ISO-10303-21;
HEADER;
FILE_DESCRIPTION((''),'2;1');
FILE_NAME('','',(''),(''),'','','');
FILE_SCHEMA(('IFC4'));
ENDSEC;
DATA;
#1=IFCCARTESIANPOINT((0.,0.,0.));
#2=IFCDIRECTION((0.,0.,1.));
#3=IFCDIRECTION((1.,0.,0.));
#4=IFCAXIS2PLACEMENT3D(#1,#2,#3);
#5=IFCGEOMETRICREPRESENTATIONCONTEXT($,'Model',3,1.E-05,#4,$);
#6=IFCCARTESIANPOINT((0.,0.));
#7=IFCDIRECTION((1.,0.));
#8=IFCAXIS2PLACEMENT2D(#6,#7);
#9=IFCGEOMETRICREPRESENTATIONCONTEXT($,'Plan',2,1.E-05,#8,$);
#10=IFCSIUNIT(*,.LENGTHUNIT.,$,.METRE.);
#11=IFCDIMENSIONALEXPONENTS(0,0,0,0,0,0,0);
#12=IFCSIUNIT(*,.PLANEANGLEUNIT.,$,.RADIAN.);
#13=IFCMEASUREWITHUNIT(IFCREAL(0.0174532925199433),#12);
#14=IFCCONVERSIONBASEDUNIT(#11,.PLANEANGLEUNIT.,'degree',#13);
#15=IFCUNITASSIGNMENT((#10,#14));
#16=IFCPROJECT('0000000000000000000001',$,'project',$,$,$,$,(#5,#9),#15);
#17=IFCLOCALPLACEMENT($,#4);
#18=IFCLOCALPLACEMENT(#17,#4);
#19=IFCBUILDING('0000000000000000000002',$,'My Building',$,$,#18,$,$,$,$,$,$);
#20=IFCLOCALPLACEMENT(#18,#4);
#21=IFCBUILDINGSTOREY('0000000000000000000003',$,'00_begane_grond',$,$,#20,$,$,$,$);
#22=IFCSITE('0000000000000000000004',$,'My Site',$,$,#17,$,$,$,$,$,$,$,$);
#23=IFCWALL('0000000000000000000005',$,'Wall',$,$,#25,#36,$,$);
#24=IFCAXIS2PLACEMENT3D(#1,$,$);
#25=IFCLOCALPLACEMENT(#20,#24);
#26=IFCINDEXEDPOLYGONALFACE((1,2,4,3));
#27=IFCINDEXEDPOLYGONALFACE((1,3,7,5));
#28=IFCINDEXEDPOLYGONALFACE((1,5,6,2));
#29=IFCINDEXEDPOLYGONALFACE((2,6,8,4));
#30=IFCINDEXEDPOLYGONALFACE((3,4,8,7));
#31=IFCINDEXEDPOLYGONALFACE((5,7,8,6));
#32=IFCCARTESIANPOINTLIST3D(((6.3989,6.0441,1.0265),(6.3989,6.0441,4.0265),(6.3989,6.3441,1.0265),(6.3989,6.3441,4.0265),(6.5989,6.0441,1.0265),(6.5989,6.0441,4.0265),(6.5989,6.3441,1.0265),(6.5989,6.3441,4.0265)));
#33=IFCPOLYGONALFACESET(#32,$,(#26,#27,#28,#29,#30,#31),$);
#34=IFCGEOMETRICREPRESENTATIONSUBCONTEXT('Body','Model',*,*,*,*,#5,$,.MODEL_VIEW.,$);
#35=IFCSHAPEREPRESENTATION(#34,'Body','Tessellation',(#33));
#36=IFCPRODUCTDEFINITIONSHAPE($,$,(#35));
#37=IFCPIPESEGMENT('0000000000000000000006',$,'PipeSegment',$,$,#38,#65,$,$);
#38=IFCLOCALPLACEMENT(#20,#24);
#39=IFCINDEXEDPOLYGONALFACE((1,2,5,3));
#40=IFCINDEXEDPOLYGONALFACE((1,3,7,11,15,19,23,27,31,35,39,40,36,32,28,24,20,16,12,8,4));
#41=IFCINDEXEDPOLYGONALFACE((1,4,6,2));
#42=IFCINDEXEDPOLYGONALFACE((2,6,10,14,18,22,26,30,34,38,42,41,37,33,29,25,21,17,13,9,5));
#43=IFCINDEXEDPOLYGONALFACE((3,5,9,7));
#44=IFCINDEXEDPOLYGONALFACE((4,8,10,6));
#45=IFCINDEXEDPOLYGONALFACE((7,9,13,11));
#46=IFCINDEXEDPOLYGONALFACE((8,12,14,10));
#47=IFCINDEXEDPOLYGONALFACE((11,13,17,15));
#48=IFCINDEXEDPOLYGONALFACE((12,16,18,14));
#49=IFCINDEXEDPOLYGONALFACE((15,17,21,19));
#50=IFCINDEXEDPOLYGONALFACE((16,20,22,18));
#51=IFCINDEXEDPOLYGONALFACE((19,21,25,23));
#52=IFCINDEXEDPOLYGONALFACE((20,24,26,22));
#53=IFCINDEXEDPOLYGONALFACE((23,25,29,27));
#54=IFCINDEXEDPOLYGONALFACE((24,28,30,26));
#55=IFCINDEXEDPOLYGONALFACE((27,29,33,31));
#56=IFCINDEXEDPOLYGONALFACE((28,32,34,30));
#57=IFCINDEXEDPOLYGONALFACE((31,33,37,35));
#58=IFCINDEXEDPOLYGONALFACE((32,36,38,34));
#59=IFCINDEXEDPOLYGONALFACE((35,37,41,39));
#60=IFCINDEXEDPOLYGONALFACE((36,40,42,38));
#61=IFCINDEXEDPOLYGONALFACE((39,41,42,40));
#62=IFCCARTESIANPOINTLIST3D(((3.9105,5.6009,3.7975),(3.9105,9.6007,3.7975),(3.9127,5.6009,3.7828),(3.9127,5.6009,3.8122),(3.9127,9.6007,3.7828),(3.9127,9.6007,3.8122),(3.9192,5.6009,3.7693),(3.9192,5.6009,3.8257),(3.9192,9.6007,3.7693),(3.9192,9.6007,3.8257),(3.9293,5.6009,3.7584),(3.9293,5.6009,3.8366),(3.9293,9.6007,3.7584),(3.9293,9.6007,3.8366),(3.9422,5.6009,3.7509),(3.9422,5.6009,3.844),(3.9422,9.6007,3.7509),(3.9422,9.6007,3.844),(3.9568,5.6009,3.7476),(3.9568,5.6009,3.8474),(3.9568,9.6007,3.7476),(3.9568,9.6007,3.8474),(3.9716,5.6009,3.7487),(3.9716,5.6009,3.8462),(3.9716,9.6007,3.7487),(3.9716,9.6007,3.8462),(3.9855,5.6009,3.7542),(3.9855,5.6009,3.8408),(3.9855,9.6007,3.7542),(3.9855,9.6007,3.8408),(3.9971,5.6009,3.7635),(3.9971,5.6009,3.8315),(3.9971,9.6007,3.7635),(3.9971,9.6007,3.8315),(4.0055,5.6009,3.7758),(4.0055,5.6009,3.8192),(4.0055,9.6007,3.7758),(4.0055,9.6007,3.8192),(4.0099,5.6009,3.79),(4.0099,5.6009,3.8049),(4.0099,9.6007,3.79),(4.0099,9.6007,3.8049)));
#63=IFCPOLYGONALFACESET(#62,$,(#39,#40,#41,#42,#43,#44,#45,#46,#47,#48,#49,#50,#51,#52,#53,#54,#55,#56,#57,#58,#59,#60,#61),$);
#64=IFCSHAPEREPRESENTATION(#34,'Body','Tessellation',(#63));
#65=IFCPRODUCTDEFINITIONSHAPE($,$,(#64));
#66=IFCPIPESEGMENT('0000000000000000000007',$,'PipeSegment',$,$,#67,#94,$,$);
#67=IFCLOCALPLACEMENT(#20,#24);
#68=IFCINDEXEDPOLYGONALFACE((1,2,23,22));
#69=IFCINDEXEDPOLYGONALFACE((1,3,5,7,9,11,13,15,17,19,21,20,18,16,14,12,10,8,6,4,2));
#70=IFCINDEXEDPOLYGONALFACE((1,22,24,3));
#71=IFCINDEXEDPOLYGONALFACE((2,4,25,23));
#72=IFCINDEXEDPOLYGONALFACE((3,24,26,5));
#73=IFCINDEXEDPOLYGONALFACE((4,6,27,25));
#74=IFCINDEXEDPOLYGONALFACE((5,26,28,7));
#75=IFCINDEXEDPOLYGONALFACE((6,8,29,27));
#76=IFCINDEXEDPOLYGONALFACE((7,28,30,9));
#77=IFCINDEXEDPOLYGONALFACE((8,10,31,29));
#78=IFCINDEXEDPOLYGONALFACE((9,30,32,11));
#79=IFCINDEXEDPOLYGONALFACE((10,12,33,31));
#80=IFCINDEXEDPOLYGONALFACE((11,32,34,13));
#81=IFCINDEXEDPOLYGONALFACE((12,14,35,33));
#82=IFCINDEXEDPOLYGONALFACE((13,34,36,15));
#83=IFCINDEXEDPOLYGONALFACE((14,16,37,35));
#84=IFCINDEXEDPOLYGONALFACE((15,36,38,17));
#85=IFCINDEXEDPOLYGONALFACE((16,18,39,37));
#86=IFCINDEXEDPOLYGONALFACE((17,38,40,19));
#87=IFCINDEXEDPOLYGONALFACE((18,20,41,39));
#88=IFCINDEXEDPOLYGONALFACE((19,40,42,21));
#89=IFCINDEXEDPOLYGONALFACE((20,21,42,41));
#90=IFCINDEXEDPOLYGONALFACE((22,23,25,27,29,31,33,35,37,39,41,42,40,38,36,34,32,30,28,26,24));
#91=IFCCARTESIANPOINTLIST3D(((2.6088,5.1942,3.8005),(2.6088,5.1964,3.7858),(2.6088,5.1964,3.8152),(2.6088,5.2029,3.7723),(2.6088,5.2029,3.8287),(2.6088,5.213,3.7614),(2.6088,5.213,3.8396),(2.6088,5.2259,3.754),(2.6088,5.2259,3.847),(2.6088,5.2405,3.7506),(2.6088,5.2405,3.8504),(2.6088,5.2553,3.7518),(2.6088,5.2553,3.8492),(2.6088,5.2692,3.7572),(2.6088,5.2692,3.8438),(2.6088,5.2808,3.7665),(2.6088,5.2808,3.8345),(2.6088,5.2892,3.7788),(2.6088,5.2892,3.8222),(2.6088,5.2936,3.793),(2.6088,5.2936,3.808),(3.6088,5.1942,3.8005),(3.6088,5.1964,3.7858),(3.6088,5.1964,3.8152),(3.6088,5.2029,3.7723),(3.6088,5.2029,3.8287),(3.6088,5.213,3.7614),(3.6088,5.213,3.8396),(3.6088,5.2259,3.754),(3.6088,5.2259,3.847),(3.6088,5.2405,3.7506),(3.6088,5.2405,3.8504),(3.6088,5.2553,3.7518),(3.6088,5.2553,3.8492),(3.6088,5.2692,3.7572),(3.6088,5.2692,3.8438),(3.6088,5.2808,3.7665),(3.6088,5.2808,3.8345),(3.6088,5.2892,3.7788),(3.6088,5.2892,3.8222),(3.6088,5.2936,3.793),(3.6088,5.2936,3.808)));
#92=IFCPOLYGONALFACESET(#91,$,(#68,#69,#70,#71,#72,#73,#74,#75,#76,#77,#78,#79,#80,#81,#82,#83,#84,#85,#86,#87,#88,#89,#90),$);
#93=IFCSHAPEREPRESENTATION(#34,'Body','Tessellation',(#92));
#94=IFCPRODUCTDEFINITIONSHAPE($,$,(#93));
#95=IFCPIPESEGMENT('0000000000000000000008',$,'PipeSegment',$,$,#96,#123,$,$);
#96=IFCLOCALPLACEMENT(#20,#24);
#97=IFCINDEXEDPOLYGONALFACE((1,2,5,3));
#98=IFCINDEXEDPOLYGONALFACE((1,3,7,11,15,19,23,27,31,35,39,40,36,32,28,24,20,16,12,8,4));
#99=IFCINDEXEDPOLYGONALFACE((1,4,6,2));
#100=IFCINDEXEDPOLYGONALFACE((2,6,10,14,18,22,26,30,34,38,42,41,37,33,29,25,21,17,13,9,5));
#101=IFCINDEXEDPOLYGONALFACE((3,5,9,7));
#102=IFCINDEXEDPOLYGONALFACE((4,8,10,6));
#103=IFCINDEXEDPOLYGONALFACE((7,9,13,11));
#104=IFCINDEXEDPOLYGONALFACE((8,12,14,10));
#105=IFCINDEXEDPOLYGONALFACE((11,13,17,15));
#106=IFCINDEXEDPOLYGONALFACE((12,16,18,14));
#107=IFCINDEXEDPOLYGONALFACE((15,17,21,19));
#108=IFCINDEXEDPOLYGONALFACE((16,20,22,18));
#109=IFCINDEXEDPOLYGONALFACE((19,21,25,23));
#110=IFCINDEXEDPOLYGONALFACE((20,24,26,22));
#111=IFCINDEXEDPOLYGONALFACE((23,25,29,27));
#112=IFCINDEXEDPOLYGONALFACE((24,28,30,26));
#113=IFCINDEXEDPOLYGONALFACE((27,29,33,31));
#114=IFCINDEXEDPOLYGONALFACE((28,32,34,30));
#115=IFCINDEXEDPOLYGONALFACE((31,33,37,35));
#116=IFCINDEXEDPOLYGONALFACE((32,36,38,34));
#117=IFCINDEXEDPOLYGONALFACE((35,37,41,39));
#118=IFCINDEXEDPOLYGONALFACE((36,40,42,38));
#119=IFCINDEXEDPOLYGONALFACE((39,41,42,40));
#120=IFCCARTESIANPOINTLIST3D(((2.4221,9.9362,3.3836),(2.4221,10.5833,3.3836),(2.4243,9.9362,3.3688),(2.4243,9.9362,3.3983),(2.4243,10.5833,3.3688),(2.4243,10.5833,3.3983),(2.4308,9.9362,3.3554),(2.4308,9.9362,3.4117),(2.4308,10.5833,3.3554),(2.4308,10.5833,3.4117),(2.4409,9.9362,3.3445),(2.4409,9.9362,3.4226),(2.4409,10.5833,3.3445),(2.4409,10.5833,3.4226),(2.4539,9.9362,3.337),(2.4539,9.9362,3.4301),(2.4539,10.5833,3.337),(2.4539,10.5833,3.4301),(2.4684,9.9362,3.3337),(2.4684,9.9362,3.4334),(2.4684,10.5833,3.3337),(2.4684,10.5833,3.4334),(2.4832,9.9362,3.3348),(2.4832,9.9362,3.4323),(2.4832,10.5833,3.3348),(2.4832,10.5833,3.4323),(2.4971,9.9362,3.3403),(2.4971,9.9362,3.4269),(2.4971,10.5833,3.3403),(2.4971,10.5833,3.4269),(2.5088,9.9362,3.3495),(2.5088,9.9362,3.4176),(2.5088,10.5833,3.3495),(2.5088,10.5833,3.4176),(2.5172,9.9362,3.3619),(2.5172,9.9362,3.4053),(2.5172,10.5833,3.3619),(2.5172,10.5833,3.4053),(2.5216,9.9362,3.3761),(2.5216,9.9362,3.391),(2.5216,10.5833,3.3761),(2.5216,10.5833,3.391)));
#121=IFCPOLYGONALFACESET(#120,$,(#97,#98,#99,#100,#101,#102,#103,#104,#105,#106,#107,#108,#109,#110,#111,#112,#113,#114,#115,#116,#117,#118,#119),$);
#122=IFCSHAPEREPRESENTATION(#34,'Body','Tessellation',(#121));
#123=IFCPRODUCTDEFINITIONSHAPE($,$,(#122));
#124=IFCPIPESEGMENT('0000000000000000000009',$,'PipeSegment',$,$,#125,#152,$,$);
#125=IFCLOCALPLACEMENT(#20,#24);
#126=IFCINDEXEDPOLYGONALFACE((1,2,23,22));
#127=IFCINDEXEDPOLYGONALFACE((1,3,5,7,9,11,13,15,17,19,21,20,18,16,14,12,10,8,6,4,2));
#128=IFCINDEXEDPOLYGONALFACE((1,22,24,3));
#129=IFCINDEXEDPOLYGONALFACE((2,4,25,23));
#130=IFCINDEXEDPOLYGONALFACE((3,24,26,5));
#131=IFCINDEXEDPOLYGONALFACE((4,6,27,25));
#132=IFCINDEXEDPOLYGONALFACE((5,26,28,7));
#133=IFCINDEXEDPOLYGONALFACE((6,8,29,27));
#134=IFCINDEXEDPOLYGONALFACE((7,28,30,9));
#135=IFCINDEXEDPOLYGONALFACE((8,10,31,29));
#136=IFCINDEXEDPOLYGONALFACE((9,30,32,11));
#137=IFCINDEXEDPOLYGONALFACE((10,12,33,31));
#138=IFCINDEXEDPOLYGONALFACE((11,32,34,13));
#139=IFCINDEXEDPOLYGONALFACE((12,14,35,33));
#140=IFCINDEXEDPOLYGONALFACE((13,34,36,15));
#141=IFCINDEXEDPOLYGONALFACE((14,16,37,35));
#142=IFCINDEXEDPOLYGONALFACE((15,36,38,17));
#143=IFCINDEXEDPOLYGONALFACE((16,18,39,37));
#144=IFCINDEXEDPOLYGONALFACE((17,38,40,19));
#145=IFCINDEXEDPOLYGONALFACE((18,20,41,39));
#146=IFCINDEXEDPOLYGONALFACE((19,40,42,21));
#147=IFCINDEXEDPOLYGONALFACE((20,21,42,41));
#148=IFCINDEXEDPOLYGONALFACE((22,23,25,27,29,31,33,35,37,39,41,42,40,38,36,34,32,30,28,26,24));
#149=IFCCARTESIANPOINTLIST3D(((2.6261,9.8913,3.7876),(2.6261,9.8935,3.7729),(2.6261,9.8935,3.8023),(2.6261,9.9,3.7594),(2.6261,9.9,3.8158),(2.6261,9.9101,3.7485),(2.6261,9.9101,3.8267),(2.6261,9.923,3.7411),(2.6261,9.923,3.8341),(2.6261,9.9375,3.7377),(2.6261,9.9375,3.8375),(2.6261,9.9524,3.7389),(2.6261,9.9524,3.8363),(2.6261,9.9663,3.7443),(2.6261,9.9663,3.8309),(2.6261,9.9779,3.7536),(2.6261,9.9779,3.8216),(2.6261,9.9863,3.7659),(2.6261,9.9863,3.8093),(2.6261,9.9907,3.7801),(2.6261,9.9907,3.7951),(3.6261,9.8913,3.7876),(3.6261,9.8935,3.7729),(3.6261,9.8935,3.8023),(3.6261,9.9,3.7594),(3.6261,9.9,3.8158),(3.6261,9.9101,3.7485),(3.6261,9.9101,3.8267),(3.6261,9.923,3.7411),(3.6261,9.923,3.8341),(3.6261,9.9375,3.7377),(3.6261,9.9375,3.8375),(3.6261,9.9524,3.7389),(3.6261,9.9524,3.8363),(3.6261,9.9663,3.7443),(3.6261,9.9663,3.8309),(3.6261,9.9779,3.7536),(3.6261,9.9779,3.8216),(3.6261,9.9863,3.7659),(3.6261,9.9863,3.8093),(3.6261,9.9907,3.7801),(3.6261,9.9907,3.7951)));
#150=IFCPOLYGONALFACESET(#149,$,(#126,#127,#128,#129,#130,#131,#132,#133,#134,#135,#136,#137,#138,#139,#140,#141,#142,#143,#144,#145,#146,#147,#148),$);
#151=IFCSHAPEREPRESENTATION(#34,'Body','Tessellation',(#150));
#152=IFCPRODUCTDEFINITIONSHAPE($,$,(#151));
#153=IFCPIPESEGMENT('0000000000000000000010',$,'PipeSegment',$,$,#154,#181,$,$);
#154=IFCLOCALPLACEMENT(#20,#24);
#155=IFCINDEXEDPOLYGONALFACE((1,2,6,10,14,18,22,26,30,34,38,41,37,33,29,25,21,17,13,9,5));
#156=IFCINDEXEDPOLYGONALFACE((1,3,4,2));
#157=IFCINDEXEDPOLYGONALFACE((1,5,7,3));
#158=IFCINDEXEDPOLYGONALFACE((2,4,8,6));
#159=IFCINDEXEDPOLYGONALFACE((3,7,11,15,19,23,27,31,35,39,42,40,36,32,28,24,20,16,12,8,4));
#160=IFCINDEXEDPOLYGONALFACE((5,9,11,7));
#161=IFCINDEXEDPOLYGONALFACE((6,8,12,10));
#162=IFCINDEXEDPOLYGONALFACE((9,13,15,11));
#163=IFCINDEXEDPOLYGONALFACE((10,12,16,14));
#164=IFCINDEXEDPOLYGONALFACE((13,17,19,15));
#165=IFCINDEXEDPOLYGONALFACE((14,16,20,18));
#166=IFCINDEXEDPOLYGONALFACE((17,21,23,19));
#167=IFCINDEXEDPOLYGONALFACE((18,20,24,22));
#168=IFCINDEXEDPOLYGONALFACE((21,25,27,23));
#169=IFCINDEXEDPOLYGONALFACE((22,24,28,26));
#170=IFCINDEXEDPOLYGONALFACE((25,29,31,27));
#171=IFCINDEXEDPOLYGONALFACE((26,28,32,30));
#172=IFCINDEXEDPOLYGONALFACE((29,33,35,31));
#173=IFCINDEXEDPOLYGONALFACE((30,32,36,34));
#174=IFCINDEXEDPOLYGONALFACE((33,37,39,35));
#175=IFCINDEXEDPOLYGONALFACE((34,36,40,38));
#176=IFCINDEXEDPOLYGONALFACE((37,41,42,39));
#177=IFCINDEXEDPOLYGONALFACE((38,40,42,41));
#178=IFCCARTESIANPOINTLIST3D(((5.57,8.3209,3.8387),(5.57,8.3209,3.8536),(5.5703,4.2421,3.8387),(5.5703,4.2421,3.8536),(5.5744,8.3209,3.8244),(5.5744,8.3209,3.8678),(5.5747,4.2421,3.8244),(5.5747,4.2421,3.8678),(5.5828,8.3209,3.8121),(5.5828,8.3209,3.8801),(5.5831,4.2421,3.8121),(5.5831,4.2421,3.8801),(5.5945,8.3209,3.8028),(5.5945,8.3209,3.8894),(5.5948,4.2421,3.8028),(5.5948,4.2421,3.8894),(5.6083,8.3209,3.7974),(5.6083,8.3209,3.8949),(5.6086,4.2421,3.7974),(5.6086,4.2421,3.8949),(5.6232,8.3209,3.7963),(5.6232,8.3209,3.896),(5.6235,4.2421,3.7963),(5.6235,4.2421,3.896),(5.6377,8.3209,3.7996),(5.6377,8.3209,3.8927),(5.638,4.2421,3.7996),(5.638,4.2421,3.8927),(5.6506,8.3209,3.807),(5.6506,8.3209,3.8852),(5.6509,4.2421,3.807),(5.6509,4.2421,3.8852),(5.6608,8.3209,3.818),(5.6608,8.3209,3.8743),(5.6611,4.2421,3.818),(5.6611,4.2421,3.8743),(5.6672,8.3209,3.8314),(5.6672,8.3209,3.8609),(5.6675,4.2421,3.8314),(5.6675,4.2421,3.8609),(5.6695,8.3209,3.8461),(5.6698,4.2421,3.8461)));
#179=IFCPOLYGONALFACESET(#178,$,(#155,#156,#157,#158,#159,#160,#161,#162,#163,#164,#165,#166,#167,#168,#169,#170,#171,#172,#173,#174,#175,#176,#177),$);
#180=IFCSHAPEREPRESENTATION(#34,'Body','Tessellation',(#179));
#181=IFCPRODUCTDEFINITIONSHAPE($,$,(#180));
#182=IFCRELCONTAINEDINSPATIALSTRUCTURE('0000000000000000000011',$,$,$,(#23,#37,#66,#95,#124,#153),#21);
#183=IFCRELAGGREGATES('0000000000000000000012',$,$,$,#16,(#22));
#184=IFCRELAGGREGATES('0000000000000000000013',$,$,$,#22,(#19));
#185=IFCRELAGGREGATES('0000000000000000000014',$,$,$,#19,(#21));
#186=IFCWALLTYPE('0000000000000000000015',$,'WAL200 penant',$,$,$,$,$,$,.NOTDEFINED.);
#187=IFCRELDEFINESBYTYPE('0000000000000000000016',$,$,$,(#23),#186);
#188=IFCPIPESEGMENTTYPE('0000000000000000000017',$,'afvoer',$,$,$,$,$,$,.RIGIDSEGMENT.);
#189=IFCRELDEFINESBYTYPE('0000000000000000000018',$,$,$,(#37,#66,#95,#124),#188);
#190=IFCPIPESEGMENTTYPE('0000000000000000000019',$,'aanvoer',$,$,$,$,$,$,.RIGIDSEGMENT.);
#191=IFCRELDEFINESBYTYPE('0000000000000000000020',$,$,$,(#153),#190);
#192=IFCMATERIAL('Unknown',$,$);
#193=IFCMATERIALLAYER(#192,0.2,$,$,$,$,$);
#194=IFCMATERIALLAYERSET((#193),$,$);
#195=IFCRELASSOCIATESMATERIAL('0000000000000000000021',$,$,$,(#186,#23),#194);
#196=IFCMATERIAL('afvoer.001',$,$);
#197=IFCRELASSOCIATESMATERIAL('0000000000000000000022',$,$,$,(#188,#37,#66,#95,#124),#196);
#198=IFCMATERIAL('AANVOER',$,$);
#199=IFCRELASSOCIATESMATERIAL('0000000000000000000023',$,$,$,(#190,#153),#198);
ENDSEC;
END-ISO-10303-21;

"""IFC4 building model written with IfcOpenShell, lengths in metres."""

from ifc_helpers import new_model, entity, si_unit, converted_unit, frame, origin_with_axes, origin_2d_with_axis, place, context, subcontext, project, spatial, indexed_curve, circle, outline, extrude, material, layer, layer_set, layer_usage, material_profile, profile_set, profile_usage, type_object, element, save


model = new_model("IFC4")

# Units and contexts
model_context = context("Model", 3, precision=1e-05, world=origin_with_axes())
plan_context = context("Plan", 2, precision=1e-05, world=origin_2d_with_axis())
body_context_1 = subcontext(model_context, "Body", "Model", "MODEL_VIEW")
ifc_project = project(units=[si_unit("LENGTHUNIT", "METRE"), converted_unit("PLANEANGLEUNIT", "degree", entity("IfcReal", 0.0174532925199433), si_unit("PLANEANGLEUNIT", "RADIAN"), dimensions=[0, 0, 0, 0, 0, 0, 0])], contexts=[model_context, plan_context])

# Site, building, storey
site_placement = place(None, origin_with_axes())
site = spatial("IfcSite", under=ifc_project, at=site_placement, Name="My Site")
building_placement = place(site_placement, origin_with_axes())
building = spatial("IfcBuilding", under=site, at=building_placement, Name="My Building")
storey_placement = place(building_placement, origin_with_axes())
storey = spatial("IfcBuildingStorey", under=building, at=storey_placement, Name="00_begane_grond")

# Shared definitions
ifc_material_1 = material(Name="Unknown")

# Wall
ifc_layer_1 = layer(ifc_material_1, 0.2)
ifc_layer_set_1 = layer_set([ifc_layer_1])
ifc_layer_usage_1 = layer_usage(ifc_layer_set_1, "AXIS2", "POSITIVE", 0.0)
wall_type_1 = type_object("IfcWallType", Name="WAL200 penant", PredefinedType="NOTDEFINED", material=ifc_layer_set_1)
wall_1_placement = place(storey_placement, frame((6.5989, 6.0441, 1.0265), z_axis=(0.0, 0.0, 1.0), x_axis=(0.0, 1.0, 0.0)))
element("IfcWall", 1, at=wall_1_placement, inside=storey, type_object=wall_type_1, material=ifc_layer_usage_1, Name="Wall", context=body_context_1, shape_type="SweptSolid", body=[
    extrude(outline(indexed_curve([(0.0, 0.0), (0.0, 0.2), (0.3, 0.2), (0.3, 0.0), (0.0, 0.0)], self_intersect=False)), origin_with_axes(), (0.0, 0.0, 1.0), 3.0),
])

# Pipe segments
ifc_material_2 = material(Name="afvoer.001")
ifc_material_profile_1 = material_profile(ifc_material_2, circle(Radius=0.05))
ifc_profile_set_1 = profile_set([ifc_material_profile_1])
ifc_profile_usage_1 = profile_usage(ifc_profile_set_1, cardinal=5)
pipe_segment_type_1 = type_object("IfcPipeSegmentType", Name="afvoer", PredefinedType="RIGIDSEGMENT", material=ifc_profile_set_1)
pipe_segment_1_placement = place(storey_placement, frame((3.9605, 5.6009, 3.7975), z_axis=(0.0, 1.0, 0.0), x_axis=(-1.0, 0.0, 0.0)))
element("IfcPipeSegment", 2, at=pipe_segment_1_placement, inside=storey, type_object=pipe_segment_type_1, material=ifc_profile_usage_1, Name="PipeSegment", context=body_context_1, shape_type="SweptSolid", body=[
    extrude(circle(Radius=0.05), origin_with_axes(), (0.0, 0.0, 1.0), 3.9998),
])
ifc_profile_usage_2 = profile_usage(ifc_profile_set_1, cardinal=5)
pipe_segment_2_placement = place(storey_placement, frame((3.6088, 5.2442, 3.8005), z_axis=(-1.0, 0.0, 0.0), x_axis=(0.0, -1.0, 0.0)))
element("IfcPipeSegment", 3, at=pipe_segment_2_placement, inside=storey, type_object=pipe_segment_type_1, material=ifc_profile_usage_2, Name="PipeSegment", context=body_context_1, shape_type="SweptSolid", body=[
    extrude(circle(Radius=0.05), origin_with_axes(), (0.0, 0.0, 1.0), 1.0),
])
ifc_profile_usage_3 = profile_usage(ifc_profile_set_1, cardinal=5)
pipe_segment_3_placement = place(storey_placement, frame((2.4721, 9.9362, 3.3836), z_axis=(0.0, 1.0, 0.0), x_axis=(-1.0, 0.0, 0.0)))
element("IfcPipeSegment", 4, at=pipe_segment_3_placement, inside=storey, type_object=pipe_segment_type_1, material=ifc_profile_usage_3, Name="PipeSegment", context=body_context_1, shape_type="SweptSolid", body=[
    extrude(circle(Radius=0.05), origin_with_axes(), (0.0, 0.0, 1.0), 0.6471),
])
ifc_profile_usage_4 = profile_usage(ifc_profile_set_1, cardinal=5)
pipe_segment_4_placement = place(storey_placement, frame((3.6261, 9.9413, 3.7876), z_axis=(-1.0, 0.0, 0.0), x_axis=(0.0, -1.0, 0.0)))
element("IfcPipeSegment", 5, at=pipe_segment_4_placement, inside=storey, type_object=pipe_segment_type_1, material=ifc_profile_usage_4, Name="PipeSegment", context=body_context_1, shape_type="SweptSolid", body=[
    extrude(circle(Radius=0.05), origin_with_axes(), (0.0, 0.0, 1.0), 1.0),
])
ifc_material_3 = material(Name="AANVOER")
ifc_material_profile_2 = material_profile(ifc_material_3, circle(Radius=0.05))
ifc_profile_set_2 = profile_set([ifc_material_profile_2])
ifc_profile_usage_5 = profile_usage(ifc_profile_set_2)
pipe_segment_type_2 = type_object("IfcPipeSegmentType", Name="aanvoer", PredefinedType="RIGIDSEGMENT", material=ifc_profile_set_2)
pipe_segment_5_placement = place(storey_placement, frame((5.6195, 8.3209, 3.8461), z_axis=(0.000073, -1.0, 0.0), x_axis=(1.0, 0.000073, 0.0)))
element("IfcPipeSegment", 6, at=pipe_segment_5_placement, inside=storey, type_object=pipe_segment_type_2, material=ifc_profile_usage_5, Name="PipeSegment", context=body_context_1, shape_type="SweptSolid", body=[
    extrude(circle(Radius=0.05), origin_with_axes(), (0.0, 0.0, 1.0), 4.0788),
])

save(model, "model.ifc")
